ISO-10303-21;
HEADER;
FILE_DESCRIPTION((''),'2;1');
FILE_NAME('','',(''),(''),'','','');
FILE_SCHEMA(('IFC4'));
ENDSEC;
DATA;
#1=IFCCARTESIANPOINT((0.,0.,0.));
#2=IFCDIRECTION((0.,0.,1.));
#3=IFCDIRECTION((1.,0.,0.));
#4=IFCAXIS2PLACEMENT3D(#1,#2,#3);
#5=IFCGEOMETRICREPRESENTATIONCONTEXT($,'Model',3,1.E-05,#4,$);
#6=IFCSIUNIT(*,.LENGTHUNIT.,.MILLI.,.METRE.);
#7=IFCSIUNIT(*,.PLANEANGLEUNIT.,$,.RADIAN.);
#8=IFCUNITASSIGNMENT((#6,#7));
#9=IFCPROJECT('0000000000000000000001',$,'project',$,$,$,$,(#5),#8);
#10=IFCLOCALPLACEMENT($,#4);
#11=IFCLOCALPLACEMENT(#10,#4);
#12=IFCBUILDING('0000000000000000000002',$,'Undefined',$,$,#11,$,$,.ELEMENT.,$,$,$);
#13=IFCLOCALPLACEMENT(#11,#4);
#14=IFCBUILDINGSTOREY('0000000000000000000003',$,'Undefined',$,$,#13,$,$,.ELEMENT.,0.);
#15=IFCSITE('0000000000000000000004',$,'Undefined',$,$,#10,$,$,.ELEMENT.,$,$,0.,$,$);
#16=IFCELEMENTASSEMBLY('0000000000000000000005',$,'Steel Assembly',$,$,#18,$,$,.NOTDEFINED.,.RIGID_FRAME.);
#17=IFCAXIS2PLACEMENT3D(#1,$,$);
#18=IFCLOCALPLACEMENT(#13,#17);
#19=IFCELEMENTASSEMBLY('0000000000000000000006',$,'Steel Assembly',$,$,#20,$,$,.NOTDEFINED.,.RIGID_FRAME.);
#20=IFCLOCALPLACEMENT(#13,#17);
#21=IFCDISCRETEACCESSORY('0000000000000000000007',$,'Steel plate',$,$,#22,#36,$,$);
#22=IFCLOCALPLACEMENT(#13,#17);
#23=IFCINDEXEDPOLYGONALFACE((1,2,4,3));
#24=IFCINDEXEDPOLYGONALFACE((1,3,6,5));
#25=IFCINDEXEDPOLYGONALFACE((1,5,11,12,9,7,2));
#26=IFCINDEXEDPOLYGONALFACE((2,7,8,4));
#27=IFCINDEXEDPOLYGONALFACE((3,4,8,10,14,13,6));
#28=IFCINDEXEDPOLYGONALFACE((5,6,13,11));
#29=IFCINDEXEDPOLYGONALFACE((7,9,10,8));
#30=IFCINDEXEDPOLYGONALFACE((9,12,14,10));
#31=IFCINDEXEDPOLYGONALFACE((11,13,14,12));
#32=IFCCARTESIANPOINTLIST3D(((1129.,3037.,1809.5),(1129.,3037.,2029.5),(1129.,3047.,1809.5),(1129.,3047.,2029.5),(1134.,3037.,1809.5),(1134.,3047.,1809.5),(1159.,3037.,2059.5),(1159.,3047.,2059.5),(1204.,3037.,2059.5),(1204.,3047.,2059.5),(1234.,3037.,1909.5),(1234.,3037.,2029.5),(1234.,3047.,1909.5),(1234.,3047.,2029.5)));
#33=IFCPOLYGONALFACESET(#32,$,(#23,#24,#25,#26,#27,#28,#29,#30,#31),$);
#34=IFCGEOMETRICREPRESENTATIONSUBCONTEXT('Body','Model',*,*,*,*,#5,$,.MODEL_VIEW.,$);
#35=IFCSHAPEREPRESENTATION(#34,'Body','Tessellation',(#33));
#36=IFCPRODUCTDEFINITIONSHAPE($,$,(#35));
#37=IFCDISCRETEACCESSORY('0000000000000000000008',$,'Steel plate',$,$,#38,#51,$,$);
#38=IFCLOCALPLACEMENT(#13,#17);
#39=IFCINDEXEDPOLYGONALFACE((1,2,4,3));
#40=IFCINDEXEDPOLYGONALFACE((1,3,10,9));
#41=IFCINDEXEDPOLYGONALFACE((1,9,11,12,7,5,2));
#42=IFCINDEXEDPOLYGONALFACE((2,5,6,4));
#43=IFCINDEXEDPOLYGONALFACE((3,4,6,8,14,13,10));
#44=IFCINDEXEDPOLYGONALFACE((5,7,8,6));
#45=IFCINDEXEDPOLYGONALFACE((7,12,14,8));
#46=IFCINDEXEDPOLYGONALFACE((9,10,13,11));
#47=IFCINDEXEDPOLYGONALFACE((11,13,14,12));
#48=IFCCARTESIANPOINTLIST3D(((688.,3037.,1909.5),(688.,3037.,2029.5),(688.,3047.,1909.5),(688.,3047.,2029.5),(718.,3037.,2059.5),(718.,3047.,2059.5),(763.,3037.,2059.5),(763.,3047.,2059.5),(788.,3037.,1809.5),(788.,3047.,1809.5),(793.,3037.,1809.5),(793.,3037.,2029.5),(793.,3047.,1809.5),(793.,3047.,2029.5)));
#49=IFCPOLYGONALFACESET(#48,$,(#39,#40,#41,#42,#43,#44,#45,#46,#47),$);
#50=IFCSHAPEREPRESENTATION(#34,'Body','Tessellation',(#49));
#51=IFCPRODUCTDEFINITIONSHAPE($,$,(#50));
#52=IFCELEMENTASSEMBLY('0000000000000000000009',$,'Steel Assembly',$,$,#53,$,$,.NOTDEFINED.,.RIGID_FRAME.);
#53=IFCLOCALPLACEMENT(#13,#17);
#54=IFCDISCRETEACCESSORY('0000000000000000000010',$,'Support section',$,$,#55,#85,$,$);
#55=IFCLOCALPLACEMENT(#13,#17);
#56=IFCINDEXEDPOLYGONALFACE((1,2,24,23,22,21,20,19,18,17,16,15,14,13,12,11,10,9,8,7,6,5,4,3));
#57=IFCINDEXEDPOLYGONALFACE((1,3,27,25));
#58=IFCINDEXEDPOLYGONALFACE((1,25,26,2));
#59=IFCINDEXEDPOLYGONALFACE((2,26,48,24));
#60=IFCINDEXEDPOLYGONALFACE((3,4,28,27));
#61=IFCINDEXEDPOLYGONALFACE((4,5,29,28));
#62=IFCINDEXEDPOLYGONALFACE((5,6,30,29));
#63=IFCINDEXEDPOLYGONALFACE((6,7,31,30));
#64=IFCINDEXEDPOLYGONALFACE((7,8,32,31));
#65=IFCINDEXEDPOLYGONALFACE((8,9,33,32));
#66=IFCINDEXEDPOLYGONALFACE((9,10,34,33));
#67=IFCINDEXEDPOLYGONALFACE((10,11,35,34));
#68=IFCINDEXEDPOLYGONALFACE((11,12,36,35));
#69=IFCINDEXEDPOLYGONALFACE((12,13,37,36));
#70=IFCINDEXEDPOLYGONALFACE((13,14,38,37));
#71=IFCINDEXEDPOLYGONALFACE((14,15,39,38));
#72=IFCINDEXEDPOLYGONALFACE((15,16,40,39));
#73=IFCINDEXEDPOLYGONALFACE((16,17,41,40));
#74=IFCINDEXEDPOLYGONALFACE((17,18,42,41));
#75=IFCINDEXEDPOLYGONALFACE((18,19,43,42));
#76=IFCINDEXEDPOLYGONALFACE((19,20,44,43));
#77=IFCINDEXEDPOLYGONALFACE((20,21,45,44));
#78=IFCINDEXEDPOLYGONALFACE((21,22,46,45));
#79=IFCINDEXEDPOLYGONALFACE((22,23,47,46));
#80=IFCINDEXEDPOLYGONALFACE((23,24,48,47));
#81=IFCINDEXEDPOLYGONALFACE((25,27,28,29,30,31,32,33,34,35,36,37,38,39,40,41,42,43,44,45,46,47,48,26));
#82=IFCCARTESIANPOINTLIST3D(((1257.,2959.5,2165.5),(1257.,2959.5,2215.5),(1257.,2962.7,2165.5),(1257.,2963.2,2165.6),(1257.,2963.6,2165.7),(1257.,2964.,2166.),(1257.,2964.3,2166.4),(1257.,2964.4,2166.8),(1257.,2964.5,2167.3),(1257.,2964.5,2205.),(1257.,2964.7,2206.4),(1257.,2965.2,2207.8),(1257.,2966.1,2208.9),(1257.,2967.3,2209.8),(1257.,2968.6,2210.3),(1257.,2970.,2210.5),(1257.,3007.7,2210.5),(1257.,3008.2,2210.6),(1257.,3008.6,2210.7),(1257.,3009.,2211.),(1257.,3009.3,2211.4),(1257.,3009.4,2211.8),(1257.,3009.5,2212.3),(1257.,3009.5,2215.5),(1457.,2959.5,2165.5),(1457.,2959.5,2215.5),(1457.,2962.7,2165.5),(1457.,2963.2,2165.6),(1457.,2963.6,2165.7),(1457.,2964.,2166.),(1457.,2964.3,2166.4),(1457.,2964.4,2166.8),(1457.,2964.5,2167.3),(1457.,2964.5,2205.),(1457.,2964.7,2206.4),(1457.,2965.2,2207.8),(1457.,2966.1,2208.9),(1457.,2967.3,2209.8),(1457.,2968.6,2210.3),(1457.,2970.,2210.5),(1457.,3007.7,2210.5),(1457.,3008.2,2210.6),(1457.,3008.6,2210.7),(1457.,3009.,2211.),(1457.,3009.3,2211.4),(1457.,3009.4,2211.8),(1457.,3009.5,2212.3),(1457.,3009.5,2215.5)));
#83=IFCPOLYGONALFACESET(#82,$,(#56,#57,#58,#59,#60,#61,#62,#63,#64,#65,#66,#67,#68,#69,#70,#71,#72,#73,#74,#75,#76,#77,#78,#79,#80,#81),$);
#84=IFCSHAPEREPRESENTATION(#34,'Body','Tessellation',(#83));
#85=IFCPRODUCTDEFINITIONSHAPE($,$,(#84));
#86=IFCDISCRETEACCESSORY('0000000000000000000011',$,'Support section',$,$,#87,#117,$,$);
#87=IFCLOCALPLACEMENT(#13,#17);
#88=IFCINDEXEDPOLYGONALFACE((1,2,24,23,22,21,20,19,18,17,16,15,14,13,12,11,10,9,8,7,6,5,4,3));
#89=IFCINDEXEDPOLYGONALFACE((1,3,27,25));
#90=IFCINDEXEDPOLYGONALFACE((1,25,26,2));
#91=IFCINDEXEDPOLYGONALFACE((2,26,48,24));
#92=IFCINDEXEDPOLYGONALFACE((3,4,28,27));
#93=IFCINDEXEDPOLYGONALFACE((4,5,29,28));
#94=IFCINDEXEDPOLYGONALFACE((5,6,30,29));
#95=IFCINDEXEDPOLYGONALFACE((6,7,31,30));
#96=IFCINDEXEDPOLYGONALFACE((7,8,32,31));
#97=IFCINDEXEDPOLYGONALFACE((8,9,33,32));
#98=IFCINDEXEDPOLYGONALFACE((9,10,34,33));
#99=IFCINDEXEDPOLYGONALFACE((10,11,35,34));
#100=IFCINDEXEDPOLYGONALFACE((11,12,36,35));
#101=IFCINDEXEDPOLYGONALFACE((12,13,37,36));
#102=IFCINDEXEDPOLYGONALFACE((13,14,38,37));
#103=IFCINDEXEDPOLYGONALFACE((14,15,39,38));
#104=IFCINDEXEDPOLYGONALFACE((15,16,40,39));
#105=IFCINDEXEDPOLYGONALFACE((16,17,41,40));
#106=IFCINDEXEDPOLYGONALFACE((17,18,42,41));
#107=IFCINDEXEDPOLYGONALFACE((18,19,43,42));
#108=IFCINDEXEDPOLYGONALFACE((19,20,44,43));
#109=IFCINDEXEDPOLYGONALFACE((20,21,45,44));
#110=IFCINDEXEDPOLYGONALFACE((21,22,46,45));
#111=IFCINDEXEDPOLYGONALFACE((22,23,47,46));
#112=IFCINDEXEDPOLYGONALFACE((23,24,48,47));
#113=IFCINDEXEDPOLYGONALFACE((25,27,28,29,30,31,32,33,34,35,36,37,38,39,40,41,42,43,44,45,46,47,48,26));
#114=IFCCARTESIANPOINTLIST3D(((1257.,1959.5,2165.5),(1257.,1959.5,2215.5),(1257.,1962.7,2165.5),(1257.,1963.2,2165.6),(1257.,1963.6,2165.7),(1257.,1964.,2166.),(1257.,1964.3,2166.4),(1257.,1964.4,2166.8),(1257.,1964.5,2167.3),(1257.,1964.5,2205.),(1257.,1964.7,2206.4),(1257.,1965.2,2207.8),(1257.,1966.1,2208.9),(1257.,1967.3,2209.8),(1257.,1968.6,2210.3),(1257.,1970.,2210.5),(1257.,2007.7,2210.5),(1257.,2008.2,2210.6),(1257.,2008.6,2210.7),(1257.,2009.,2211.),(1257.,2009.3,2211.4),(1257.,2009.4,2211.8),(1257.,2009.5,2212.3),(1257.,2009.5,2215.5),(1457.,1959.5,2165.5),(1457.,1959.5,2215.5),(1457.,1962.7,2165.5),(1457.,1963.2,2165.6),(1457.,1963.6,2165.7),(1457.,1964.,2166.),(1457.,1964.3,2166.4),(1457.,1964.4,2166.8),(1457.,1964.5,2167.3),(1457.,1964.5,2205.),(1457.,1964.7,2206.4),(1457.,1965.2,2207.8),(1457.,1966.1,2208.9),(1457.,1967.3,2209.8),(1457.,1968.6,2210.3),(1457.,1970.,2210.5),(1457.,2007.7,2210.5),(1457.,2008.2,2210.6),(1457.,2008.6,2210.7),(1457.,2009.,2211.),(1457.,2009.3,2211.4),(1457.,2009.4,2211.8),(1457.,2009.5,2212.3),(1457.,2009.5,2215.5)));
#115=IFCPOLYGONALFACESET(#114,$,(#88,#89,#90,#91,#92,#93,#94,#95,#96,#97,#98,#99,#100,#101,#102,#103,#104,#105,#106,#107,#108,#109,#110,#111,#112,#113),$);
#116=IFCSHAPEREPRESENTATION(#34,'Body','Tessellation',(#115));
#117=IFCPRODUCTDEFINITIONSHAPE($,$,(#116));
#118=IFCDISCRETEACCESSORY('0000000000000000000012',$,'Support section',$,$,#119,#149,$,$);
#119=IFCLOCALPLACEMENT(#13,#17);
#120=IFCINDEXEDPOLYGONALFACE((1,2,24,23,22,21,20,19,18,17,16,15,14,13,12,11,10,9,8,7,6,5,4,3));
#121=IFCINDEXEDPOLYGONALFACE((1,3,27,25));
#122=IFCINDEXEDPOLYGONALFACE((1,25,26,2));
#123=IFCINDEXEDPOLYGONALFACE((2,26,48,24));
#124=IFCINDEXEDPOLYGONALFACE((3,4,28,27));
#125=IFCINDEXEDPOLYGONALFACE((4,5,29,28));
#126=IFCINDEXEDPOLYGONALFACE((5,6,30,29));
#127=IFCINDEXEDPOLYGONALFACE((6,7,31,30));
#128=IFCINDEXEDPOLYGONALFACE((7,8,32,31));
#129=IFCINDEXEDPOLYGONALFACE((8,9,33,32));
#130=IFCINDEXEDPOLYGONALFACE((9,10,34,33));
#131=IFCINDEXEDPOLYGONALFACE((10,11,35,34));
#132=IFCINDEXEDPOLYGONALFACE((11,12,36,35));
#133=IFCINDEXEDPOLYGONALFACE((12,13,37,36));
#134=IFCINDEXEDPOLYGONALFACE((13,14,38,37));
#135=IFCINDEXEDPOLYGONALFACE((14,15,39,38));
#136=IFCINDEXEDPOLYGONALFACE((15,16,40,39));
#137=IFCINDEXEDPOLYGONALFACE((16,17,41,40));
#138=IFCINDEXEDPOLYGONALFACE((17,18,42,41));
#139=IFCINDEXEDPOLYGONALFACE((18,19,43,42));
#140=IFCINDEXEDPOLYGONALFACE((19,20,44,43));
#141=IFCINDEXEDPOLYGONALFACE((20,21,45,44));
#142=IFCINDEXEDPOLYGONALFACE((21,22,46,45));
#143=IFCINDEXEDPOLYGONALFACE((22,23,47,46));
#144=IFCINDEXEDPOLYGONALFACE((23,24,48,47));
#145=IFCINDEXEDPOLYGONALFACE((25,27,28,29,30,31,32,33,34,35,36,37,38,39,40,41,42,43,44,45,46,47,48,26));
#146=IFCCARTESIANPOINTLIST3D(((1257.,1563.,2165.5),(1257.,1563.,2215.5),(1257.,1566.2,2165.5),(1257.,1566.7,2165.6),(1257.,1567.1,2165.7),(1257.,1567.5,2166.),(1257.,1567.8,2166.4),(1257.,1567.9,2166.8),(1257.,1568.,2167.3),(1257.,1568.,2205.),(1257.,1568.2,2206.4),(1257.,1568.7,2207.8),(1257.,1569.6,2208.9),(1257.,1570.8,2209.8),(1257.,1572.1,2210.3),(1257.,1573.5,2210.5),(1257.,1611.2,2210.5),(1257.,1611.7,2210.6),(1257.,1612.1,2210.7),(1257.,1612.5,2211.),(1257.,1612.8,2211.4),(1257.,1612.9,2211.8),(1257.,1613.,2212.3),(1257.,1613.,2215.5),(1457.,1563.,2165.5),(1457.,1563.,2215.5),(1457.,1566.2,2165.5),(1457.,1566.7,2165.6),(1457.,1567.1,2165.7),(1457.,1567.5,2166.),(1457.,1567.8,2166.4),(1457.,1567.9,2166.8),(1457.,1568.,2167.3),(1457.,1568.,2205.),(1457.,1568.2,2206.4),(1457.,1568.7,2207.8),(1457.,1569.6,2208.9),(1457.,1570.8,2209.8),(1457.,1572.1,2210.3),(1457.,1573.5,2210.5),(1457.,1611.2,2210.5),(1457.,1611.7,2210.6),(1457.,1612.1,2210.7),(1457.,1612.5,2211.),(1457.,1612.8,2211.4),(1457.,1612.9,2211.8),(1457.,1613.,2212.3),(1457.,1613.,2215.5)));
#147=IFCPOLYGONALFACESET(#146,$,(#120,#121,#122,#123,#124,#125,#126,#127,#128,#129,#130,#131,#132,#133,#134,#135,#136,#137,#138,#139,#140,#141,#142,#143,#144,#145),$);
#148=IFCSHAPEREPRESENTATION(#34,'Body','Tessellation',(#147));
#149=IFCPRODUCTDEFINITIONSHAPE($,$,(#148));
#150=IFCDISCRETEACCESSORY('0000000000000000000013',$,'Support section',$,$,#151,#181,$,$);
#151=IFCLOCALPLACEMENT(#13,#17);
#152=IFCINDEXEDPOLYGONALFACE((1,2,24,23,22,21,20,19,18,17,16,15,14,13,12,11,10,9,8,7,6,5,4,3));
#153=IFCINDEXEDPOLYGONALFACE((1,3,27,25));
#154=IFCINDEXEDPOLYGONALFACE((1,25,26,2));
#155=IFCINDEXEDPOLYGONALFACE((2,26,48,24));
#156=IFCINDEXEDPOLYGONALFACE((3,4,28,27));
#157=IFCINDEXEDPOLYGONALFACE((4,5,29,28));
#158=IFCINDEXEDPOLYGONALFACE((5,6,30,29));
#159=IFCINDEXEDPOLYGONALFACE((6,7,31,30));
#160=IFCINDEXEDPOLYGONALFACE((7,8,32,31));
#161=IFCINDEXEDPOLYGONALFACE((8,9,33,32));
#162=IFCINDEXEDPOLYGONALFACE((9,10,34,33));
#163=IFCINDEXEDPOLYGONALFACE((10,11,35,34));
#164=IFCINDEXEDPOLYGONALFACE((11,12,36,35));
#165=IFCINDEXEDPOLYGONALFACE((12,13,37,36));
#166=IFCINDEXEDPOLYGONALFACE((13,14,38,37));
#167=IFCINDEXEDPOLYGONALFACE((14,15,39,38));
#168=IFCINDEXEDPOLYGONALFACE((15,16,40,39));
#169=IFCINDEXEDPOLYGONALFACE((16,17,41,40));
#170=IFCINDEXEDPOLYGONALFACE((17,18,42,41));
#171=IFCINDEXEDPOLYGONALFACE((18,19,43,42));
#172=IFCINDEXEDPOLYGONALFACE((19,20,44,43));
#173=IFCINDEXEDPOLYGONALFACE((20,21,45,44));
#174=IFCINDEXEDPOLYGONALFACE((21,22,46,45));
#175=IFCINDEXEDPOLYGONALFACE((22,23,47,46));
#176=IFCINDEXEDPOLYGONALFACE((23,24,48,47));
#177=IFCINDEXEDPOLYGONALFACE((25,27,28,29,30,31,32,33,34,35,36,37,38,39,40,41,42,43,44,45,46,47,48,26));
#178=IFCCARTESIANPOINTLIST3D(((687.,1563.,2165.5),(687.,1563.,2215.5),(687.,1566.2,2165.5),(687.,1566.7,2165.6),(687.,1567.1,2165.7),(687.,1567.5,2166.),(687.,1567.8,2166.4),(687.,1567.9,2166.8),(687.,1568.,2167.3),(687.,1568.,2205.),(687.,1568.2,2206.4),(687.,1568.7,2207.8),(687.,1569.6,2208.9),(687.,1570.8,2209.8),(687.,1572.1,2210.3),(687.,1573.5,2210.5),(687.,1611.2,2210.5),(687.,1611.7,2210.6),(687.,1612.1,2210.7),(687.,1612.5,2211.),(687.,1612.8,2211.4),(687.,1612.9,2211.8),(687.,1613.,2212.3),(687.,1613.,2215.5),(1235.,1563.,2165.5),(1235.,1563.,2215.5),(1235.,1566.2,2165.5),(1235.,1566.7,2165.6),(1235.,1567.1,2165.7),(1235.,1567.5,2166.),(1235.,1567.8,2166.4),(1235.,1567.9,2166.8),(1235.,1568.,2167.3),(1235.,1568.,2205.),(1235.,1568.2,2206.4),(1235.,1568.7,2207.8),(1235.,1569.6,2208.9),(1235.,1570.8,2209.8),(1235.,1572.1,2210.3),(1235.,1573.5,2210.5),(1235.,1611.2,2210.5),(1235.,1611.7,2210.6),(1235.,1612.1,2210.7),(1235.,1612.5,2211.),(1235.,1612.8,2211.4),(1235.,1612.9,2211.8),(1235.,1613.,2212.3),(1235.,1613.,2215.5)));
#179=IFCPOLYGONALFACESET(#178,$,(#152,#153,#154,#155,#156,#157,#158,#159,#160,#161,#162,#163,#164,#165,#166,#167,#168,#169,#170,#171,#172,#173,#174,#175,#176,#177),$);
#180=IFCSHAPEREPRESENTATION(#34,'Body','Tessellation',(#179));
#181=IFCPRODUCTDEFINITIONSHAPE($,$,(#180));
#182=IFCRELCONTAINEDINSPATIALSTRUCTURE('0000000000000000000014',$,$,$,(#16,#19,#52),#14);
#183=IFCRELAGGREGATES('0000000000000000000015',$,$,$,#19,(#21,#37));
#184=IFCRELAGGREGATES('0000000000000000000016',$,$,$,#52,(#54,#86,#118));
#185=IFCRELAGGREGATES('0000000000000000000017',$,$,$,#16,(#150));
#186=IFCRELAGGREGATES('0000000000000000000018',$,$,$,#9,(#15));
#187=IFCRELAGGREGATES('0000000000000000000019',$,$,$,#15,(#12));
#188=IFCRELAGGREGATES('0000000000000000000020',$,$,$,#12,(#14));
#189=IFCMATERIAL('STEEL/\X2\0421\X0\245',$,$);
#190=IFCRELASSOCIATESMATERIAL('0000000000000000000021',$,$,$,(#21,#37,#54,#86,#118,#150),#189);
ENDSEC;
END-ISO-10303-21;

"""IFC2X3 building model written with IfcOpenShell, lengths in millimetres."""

from ifc_helpers import new_model, si_unit, frame, origin_with_axes, origin_2d_with_axis, place, context, subcontext, project, spatial, polyline, l_section, outline, extrude, material, element, aggregate, save


model = new_model("IFC2X3")

# Units and contexts
model_context = context("Model", 3, precision=1e-05, world=origin_with_axes())
body_context = subcontext(model_context, "Body", "Model", "MODEL_VIEW")
ifc_project = project(units=[si_unit("LENGTHUNIT", "METRE", prefix="MILLI"), si_unit("PLANEANGLEUNIT", "RADIAN")], contexts=[model_context])

# Site, building, storey
site_placement = place(None, origin_with_axes())
site = spatial("IfcSite", under=ifc_project, at=site_placement, Name="Undefined", CompositionType="ELEMENT", RefElevation=0.0)
building_placement = place(site_placement, origin_with_axes())
building = spatial("IfcBuilding", under=site, at=building_placement, Name="Undefined", CompositionType="ELEMENT")
storey_placement = place(building_placement, origin_with_axes())
storey = spatial("IfcBuildingStorey", under=building, at=storey_placement, Name="Undefined", CompositionType="ELEMENT", Elevation=0.0)

# Shared definitions
ifc_material_1 = material(Name="STEEL/С245")

# Element assembly
assembly_1_placement = place(storey_placement, origin_with_axes())
assembly_1 = element("IfcElementAssembly", 1, at=assembly_1_placement, inside=storey, Name="Steel Assembly", AssemblyPlace="NOTDEFINED", PredefinedType="RIGID_FRAME")

# Element assemblies, discrete accessories
assembly_2_placement = place(storey_placement, origin_with_axes())
assembly_2 = element("IfcElementAssembly", 2, at=assembly_2_placement, inside=storey, Name="Steel Assembly", AssemblyPlace="NOTDEFINED", PredefinedType="RIGID_FRAME")
discrete_accessory_1_placement = place(assembly_2_placement, frame((1129.0, 3042.0, 2059.5), z_axis=(0.0, 1.0, 0.0), x_axis=(1.0, 0.0, 0.0)))
discrete_accessory_1 = element("IfcDiscreteAccessory", 3, at=discrete_accessory_1_placement, material=ifc_material_1, Name="Steel plate", context=body_context, shape_type="SweptSolid", body=[
    extrude(outline(polyline([(0.0, 30.0), (30.0, 0.0), (75.0, 0.0), (105.0, 30.0), (105.0, 150.0), (5.0, 250.0), (0.0, 250.0), (0.0, 30.0)])), frame((0.0, 0.0, -5.0), z_axis=(0.0, 0.0, 1.0), x_axis=(1.0, 0.0, 0.0)), (0.0, 0.0, 1.0), 10.0),
])
discrete_accessory_2_placement = place(assembly_2_placement, frame((793.0, 3042.0, 2059.5), z_axis=(0.0, -1.0, 0.0), x_axis=(-1.0, 0.0, 0.0)))
discrete_accessory_2 = element("IfcDiscreteAccessory", 4, at=discrete_accessory_2_placement, material=ifc_material_1, Name="Steel plate", context=body_context, shape_type="SweptSolid", body=[
    extrude(outline(polyline([(0.0, 30.0), (30.0, 0.0), (75.0, 0.0), (105.0, 30.0), (105.0, 150.0), (5.0, 250.0), (0.0, 250.0), (0.0, 30.0)])), frame((0.0, 0.0, -5.0), z_axis=(0.0, 0.0, 1.0), x_axis=(1.0, 0.0, 0.0)), (0.0, 0.0, 1.0), 10.0),
])
aggregate(assembly_2, [discrete_accessory_1, discrete_accessory_2])
assembly_3_placement = place(storey_placement, origin_with_axes())
assembly_3 = element("IfcElementAssembly", 5, at=assembly_3_placement, inside=storey, Name="Steel Assembly", AssemblyPlace="NOTDEFINED", PredefinedType="RIGID_FRAME")
discrete_accessory_3_placement = place(assembly_3_placement, frame((1457.0, 2984.5, 2190.5), z_axis=(0.0, 1.0, 0.0), x_axis=(-1.0, 0.0, 0.0)))
discrete_accessory_3 = element("IfcDiscreteAccessory", 6, at=discrete_accessory_3_placement, material=ifc_material_1, Name="Support section", context=body_context, shape_type="SweptSolid", body=[
    extrude(l_section(Depth=50.0, Width=50.0, Thickness=5.0, FilletRadius=5.5, EdgeRadius=1.8, at=origin_2d_with_axis()), frame((200.0, 0.0, 0.0), z_axis=(-1.0, 0.0, 0.0), x_axis=(0.0, -1.0, 0.0)), (0.0, 0.0, 1.0), 200.0),
])
discrete_accessory_4_placement = place(assembly_3_placement, frame((1457.0, 1984.5, 2190.5), z_axis=(0.0, 1.0, 0.0), x_axis=(-1.0, 0.0, 0.0)))
discrete_accessory_4 = element("IfcDiscreteAccessory", 7, at=discrete_accessory_4_placement, material=ifc_material_1, Name="Support section", context=body_context, shape_type="SweptSolid", body=[
    extrude(l_section(Depth=50.0, Width=50.0, Thickness=5.0, FilletRadius=5.5, EdgeRadius=1.8, at=origin_2d_with_axis()), frame((200.0, 0.0, 0.0), z_axis=(-1.0, 0.0, 0.0), x_axis=(0.0, -1.0, 0.0)), (0.0, 0.0, 1.0), 200.0),
])
discrete_accessory_5_placement = place(assembly_3_placement, frame((1457.0, 1588.0, 2190.5), z_axis=(0.0, 1.0, 0.0), x_axis=(-1.0, 0.0, 0.0)))
discrete_accessory_5 = element("IfcDiscreteAccessory", 8, at=discrete_accessory_5_placement, material=ifc_material_1, Name="Support section", context=body_context, shape_type="SweptSolid", body=[
    extrude(l_section(Depth=50.0, Width=50.0, Thickness=5.0, FilletRadius=5.5, EdgeRadius=1.8, at=origin_2d_with_axis()), frame((200.0, 0.0, 0.0), z_axis=(-1.0, 0.0, 0.0), x_axis=(0.0, -1.0, 0.0)), (0.0, 0.0, 1.0), 200.0),
])
aggregate(assembly_3, [discrete_accessory_3, discrete_accessory_4, discrete_accessory_5])

# Discrete accessory
discrete_accessory_6_placement = place(assembly_1_placement, frame((1235.0, 1588.0, 2190.5), z_axis=(0.0, 1.0, 0.0), x_axis=(-1.0, 0.0, 0.0)))
discrete_accessory_6 = element("IfcDiscreteAccessory", 9, at=discrete_accessory_6_placement, material=ifc_material_1, Name="Support section", context=body_context, shape_type="SweptSolid", body=[
    extrude(l_section(Depth=50.0, Width=50.0, Thickness=5.0, FilletRadius=5.5, EdgeRadius=1.8, at=origin_2d_with_axis()), frame((548.0, 0.0, 0.0), z_axis=(-1.0, 0.0, 0.0), x_axis=(0.0, -1.0, 0.0)), (0.0, 0.0, 1.0), 548.0),
])
aggregate(assembly_1, [discrete_accessory_6])

save(model, "model.ifc")
